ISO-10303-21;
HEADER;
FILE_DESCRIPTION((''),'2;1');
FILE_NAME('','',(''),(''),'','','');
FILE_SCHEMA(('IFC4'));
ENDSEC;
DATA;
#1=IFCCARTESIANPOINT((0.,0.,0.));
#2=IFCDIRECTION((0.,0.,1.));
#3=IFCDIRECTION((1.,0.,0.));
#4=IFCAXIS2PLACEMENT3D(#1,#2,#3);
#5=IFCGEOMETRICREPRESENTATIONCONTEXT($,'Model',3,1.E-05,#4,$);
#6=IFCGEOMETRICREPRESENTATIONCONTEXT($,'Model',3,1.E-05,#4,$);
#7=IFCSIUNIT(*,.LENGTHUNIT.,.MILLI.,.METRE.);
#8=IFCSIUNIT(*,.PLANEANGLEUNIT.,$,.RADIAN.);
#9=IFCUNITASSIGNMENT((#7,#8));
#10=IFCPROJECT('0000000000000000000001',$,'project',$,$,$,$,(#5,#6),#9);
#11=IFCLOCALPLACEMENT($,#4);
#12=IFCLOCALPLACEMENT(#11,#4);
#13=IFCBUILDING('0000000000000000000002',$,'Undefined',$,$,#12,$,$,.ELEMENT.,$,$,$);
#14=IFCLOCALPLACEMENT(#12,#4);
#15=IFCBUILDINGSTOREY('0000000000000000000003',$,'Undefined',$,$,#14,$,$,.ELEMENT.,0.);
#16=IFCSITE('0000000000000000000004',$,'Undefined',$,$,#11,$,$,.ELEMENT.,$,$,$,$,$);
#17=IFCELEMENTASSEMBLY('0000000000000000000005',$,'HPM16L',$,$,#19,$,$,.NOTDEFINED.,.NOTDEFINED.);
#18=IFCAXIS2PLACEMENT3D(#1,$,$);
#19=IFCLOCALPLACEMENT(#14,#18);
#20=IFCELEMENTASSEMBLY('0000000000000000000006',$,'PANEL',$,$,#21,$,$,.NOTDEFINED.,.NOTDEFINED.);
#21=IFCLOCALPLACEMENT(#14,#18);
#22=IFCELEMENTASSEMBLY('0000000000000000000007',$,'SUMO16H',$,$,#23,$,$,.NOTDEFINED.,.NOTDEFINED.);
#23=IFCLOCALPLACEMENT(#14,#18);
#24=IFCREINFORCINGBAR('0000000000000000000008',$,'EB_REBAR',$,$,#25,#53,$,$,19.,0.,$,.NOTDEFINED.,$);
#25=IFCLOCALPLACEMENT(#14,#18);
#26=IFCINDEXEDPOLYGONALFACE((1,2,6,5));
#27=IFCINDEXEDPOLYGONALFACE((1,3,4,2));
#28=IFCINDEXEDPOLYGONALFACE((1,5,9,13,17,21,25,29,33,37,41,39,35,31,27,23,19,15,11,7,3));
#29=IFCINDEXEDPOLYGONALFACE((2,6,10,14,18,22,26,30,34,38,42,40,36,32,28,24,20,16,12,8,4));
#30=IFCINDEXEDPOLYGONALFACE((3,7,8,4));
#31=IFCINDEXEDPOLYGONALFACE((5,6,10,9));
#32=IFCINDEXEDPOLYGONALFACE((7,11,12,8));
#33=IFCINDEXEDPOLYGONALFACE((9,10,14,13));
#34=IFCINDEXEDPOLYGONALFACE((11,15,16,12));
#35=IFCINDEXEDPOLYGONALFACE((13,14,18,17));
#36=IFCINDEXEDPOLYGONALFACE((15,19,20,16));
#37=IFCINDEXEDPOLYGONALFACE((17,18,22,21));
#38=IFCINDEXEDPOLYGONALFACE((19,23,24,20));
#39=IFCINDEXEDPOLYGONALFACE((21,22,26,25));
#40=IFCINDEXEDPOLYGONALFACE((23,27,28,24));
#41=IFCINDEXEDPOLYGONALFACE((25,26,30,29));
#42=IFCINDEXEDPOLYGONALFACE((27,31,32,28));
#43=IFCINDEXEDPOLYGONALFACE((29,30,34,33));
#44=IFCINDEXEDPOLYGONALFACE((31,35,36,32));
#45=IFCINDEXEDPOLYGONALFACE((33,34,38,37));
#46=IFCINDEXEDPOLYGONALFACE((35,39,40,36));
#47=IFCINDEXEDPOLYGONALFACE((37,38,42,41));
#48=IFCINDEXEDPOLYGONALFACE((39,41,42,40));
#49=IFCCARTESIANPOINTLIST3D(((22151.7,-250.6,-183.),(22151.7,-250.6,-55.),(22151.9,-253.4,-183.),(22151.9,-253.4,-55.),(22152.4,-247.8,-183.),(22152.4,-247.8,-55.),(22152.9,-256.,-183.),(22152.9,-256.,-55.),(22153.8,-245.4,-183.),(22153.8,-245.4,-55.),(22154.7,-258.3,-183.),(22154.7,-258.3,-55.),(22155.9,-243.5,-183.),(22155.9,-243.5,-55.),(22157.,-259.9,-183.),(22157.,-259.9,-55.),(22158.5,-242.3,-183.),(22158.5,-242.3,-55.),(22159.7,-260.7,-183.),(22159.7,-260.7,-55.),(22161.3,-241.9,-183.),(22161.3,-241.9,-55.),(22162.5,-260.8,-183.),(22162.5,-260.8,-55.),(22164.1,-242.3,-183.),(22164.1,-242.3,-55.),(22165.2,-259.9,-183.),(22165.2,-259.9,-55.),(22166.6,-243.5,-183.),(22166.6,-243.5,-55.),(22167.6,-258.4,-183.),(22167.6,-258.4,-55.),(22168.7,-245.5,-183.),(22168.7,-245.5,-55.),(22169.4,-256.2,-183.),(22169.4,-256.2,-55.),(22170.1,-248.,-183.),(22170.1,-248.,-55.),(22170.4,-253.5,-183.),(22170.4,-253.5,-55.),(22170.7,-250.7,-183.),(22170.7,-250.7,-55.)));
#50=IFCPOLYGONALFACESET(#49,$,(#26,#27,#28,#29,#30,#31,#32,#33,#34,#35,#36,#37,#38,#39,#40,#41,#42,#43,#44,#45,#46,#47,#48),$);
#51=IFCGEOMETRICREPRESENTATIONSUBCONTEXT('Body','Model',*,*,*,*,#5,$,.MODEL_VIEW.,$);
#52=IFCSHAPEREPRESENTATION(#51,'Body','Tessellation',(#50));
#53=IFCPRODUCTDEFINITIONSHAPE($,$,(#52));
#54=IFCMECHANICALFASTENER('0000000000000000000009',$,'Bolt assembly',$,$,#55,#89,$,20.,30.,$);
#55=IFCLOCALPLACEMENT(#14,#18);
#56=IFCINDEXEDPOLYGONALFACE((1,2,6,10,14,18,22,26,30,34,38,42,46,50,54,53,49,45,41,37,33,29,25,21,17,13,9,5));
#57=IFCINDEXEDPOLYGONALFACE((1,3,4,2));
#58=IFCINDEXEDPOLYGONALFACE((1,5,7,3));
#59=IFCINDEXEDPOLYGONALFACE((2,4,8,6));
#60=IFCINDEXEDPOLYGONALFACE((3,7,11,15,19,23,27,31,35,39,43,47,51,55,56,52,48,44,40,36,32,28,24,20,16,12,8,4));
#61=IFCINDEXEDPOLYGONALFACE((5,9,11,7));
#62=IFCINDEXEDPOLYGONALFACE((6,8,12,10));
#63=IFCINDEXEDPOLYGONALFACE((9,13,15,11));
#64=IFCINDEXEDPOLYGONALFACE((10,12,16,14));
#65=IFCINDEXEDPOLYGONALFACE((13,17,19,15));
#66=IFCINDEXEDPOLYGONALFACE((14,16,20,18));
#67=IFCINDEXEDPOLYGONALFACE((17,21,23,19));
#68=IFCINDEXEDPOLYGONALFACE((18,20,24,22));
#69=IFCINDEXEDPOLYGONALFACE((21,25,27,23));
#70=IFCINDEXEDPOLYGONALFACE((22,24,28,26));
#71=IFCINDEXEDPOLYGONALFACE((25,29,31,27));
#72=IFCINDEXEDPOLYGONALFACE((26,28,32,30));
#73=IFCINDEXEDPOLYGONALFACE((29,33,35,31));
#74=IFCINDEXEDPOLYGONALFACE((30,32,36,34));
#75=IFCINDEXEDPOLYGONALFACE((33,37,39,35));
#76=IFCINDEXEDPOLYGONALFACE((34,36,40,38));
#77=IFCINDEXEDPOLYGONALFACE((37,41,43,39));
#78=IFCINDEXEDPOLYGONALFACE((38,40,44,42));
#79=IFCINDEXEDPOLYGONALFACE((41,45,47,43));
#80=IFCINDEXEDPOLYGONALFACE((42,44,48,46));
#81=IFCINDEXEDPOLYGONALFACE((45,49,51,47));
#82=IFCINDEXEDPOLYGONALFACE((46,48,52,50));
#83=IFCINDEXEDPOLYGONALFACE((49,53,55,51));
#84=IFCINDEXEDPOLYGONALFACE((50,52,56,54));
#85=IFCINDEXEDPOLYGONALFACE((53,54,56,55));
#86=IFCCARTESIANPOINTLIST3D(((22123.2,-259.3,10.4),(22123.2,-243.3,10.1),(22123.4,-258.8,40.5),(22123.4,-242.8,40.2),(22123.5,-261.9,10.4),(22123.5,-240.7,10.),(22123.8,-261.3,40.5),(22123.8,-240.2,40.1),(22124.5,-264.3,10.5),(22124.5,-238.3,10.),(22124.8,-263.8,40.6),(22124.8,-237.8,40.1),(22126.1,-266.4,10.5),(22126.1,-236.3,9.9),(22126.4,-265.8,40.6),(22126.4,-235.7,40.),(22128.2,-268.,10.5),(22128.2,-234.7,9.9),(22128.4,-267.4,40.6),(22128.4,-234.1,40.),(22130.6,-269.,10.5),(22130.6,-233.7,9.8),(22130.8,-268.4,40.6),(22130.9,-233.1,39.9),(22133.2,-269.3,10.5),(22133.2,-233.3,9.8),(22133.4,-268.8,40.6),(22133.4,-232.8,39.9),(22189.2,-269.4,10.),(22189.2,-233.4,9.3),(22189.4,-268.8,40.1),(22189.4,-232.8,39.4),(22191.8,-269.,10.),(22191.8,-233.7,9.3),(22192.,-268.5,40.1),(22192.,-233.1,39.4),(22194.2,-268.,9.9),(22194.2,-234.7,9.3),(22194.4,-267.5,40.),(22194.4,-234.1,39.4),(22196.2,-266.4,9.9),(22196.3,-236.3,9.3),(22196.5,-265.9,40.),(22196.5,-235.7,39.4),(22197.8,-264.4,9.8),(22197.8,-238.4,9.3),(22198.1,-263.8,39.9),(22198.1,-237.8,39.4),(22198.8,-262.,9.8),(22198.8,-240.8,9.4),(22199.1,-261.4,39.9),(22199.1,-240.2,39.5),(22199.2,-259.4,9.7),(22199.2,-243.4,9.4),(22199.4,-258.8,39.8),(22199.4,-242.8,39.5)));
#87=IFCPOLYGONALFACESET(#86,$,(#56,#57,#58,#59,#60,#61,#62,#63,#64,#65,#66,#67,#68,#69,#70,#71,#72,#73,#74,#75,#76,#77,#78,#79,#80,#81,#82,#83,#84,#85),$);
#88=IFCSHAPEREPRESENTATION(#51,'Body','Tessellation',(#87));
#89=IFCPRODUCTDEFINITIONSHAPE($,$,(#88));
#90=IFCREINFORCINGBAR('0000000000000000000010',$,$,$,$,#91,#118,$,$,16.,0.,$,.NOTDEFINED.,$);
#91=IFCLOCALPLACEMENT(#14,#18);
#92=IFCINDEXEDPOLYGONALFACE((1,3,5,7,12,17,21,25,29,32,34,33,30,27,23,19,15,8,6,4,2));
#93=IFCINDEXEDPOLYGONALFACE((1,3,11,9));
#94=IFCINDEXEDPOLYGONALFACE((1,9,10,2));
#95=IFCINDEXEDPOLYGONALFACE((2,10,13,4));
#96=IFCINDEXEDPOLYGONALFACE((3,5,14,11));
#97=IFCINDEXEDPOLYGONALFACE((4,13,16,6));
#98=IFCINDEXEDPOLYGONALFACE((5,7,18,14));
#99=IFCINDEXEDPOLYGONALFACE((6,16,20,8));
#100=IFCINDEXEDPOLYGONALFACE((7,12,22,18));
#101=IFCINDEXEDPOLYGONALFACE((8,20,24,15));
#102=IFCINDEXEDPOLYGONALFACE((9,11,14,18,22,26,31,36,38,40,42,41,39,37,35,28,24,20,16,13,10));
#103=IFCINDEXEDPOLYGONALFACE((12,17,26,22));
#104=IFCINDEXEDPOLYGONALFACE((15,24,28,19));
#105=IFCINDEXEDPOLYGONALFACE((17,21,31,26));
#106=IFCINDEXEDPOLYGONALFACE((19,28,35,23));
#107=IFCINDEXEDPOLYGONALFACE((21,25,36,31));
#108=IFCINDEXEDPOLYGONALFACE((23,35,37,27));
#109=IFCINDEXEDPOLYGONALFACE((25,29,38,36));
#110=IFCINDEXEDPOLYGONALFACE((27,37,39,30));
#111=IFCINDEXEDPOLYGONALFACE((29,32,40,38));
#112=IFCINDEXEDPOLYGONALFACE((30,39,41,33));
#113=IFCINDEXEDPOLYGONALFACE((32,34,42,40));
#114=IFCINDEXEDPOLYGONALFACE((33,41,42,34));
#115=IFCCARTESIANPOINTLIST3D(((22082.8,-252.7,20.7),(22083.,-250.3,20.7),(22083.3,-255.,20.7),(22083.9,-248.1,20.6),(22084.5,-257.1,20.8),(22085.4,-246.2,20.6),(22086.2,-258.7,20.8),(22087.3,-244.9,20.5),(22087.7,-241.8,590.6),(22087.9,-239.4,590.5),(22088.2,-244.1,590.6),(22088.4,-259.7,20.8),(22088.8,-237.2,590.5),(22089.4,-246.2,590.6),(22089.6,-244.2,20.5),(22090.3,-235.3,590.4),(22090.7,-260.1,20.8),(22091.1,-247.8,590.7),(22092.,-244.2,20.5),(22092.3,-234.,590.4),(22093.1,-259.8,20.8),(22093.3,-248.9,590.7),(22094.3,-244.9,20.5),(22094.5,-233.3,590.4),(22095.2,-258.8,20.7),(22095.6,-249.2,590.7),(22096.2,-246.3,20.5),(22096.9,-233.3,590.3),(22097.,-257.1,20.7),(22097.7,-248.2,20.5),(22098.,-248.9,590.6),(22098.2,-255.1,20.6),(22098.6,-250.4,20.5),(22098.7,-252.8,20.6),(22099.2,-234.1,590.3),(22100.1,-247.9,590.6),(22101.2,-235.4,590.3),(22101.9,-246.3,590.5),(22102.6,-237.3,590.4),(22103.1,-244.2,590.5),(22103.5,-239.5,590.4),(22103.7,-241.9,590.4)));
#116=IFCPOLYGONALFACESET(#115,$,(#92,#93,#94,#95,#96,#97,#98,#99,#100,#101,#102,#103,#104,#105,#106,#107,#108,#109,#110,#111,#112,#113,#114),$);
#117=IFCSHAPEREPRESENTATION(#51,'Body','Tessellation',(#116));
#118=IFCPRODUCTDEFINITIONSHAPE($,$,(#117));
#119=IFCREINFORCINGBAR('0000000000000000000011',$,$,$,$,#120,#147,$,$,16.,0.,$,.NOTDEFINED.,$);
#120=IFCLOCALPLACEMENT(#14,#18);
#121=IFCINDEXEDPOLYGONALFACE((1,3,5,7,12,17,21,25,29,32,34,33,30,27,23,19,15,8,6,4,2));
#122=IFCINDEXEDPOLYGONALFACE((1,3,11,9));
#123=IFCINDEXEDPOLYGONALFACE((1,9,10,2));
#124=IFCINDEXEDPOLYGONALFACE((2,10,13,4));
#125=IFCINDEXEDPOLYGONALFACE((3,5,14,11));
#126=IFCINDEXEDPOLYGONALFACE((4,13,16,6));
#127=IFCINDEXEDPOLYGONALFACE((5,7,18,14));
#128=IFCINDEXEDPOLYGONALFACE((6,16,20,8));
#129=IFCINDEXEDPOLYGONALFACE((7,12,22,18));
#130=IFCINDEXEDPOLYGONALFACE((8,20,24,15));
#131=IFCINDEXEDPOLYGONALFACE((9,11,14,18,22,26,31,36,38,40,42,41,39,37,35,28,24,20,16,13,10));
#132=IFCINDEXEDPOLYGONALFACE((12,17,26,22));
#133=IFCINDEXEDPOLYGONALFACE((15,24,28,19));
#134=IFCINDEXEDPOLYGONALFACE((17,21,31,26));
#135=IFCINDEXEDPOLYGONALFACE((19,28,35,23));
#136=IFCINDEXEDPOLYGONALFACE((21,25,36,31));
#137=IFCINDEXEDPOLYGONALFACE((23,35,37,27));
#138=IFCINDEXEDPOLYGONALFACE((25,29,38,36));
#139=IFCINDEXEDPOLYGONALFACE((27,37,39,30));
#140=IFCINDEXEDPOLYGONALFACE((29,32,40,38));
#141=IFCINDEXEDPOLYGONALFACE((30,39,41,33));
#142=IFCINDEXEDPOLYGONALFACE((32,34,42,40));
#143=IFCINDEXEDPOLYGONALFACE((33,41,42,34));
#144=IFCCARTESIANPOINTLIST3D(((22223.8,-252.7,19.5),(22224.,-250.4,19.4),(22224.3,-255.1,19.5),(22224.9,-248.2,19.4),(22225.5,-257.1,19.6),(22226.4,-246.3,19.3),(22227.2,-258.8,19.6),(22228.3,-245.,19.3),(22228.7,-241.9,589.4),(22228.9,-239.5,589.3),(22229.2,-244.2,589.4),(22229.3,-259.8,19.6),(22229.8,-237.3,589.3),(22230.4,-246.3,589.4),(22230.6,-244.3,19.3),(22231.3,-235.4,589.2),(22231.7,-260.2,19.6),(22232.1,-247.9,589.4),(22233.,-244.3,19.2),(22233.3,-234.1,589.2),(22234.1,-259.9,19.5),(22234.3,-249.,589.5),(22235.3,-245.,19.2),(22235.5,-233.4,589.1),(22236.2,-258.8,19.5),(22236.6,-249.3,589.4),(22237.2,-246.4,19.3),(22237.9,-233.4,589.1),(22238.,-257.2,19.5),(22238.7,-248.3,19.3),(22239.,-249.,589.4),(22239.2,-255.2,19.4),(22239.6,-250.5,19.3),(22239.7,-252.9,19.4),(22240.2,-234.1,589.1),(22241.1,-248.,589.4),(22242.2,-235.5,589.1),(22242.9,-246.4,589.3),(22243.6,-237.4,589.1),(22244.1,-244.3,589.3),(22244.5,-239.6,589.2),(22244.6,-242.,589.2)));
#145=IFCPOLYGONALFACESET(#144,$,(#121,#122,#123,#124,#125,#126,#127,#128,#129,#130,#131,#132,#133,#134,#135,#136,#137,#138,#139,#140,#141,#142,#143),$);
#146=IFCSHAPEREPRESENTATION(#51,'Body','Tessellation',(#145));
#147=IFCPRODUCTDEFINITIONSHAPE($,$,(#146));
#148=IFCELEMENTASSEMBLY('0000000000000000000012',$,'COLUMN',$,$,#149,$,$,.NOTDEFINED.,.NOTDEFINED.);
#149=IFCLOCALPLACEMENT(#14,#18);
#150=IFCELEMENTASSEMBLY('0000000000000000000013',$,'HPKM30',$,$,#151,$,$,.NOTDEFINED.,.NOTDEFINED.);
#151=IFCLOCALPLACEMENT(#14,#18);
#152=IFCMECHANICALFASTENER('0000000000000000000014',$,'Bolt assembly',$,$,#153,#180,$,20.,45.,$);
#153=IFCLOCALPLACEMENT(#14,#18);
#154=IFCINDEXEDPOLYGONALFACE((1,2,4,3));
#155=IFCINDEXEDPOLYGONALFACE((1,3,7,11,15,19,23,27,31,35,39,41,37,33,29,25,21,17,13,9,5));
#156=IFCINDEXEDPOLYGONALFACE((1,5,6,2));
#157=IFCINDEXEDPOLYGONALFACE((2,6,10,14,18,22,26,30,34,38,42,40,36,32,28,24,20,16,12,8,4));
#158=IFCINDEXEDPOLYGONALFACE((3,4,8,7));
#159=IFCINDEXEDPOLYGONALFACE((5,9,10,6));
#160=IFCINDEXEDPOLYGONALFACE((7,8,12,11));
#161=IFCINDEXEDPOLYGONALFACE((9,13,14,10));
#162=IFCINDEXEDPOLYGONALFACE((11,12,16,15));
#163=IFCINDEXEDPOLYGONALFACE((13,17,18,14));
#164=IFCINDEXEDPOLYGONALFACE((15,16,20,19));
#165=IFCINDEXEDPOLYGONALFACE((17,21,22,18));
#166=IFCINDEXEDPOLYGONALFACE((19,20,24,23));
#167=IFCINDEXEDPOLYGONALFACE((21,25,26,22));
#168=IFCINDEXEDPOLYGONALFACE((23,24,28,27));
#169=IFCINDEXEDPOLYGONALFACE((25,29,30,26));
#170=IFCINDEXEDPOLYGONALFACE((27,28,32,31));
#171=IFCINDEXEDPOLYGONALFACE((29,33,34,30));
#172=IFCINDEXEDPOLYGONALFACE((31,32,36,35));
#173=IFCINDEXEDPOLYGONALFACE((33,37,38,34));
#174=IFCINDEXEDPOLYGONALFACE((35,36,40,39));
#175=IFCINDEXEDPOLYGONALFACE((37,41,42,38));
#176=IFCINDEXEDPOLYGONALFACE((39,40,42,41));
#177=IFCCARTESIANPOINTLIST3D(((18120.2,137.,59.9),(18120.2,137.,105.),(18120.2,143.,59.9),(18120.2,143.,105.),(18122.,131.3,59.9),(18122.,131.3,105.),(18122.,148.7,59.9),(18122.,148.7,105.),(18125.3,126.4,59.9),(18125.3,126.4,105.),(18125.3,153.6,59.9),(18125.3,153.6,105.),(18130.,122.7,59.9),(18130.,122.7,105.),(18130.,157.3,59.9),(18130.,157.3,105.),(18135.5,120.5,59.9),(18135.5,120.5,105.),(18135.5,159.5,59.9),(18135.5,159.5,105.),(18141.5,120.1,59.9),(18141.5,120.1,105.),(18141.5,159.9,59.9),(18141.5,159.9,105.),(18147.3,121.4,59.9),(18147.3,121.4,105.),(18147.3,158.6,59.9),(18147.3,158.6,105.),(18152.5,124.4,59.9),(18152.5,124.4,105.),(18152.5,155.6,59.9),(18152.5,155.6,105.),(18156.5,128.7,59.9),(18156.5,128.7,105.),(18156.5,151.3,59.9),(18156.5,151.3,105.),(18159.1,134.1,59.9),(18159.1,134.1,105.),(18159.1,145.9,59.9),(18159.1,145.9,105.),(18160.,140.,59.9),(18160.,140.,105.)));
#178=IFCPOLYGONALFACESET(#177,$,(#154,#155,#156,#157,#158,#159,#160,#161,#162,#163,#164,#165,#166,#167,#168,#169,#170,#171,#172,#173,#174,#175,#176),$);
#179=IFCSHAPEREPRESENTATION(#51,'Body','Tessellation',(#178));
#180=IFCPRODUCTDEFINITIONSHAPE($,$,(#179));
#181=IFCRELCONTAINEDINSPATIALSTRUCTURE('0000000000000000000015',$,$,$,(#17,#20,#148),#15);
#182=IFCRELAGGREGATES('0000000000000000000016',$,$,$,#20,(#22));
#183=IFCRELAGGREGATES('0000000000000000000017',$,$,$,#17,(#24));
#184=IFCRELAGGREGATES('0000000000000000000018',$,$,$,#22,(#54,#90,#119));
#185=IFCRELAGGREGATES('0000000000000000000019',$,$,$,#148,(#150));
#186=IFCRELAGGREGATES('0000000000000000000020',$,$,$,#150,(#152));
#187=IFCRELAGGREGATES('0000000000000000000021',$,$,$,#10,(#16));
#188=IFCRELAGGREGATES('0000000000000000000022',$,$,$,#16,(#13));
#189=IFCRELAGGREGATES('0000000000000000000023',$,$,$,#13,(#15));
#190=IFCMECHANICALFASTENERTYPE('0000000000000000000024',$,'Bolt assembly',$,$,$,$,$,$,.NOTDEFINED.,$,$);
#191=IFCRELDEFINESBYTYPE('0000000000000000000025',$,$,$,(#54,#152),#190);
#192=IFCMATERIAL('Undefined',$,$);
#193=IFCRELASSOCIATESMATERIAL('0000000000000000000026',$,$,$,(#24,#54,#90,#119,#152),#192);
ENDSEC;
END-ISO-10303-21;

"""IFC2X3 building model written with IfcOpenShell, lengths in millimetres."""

from ifc_helpers import new_model, entity, si_unit, frame, frame_2d, origin_with_axes, origin_2d_with_axis, place, context, subcontext, project, spatial, polyline, circle_curve, parameter, trimmed, segment, composite_curve, circle, outline, extrude, source, transform, mapped, material, type_object, element, aggregate, save


model = new_model("IFC2X3")

# Units and contexts
model_context_1 = context("Model", 3, precision=1e-05, world=origin_with_axes())
model_context_2 = context("Model", 3, precision=1e-05, world=origin_with_axes())
body_context = subcontext(model_context_1, "Body", "Model", "MODEL_VIEW")
ifc_project = project(units=[si_unit("LENGTHUNIT", "METRE", prefix="MILLI"), si_unit("PLANEANGLEUNIT", "RADIAN")], contexts=[model_context_1, model_context_2])

# Site, building, storey
site_placement = place(None, origin_with_axes())
site = spatial("IfcSite", under=ifc_project, at=site_placement, Name="Undefined", CompositionType="ELEMENT")
building_placement = place(site_placement, origin_with_axes())
building = spatial("IfcBuilding", under=site, at=building_placement, Name="Undefined", CompositionType="ELEMENT")
storey_placement = place(building_placement, origin_with_axes())
storey = spatial("IfcBuildingStorey", under=building, at=storey_placement, Name="Undefined", CompositionType="ELEMENT", Elevation=0.0)

# Element assembly
assembly_1_placement = place(storey_placement, origin_with_axes())
assembly_1 = element("IfcElementAssembly", 1, at=assembly_1_placement, inside=storey, Name="HPM16L", AssemblyPlace="NOTDEFINED", PredefinedType="NOTDEFINED")

# Element assemblies
assembly_2_placement = place(storey_placement, origin_with_axes())
assembly_2 = element("IfcElementAssembly", 2, at=assembly_2_placement, inside=storey, Name="PANEL", AssemblyPlace="NOTDEFINED", PredefinedType="NOTDEFINED")
assembly_3_placement = place(assembly_2_placement, origin_with_axes())
assembly_3 = element("IfcElementAssembly", 3, at=assembly_3_placement, Name="SUMO16H", AssemblyPlace="NOTDEFINED", PredefinedType="NOTDEFINED")

aggregate(assembly_2, [assembly_3])

# Reinforcing bar
ifc_material_1 = material(Name="Undefined")
shared_shape_1 = source(origin_with_axes(), body_context, "Body", "AdvancedSweptSolid", [
    entity("IfcSweptDiskSolid", entity("IfcTrimmedCurve", entity("IfcLine", entity("IfcCartesianPoint", [0.0, 0.0, 0.0]), entity("IfcVector", entity("IfcDirection", [1.0, 0.0, 0.0]), 1.0)), [entity("IfcParameterValue", 0.0)], [entity("IfcParameterValue", 128.0)], True, "PARAMETER"), 9.5, None, 0.0, 128.0),
])
reinforcing_bar_1_placement = place(assembly_1_placement, frame((22161.2, -251.4, -55.0), z_axis=(0.008664, 0.999962, 0.0), x_axis=(0.0, 0.0, -1.0)))
reinforcing_bar_1 = element("IfcReinforcingBar", 4, at=reinforcing_bar_1_placement, material=ifc_material_1, Name="EB_REBAR", BarRole="NOTDEFINED", CrossSectionArea=0.0, NominalDiameter=19.0, context=body_context, shape_type="MappedRepresentation", body=[
    mapped(shared_shape_1, transform((0.0, 0.0, 0.0))),
])
aggregate(assembly_1, [reinforcing_bar_1])

# Mechanical fastener
mechanical_fastener_type = type_object("IfcMechanicalFastenerType", Name="Bolt assembly")
shared_shape_2 = source(origin_with_axes(), body_context, "Body", "SweptSolid", [
    extrude(outline(composite_curve([segment(polyline([(-28.0, 18.0), (28.0, 18.0)]), True, "CONTINUOUS"), segment(trimmed(circle_curve(frame_2d((28.0, 8.0), x_axis=(0.0, 1.0)), 10.0), [parameter(0.0)], [parameter(4.712389)], False, "PARAMETER"), True, "CONTINUOUS"), segment(polyline([(38.0, 8.0), (38.0, -8.0)]), True, "CONTINUOUS"), segment(trimmed(circle_curve(frame_2d((28.0, -8.0), x_axis=(1.0, 0.0)), 10.0), [parameter(0.0)], [parameter(4.712389)], False, "PARAMETER"), True, "CONTINUOUS"), segment(polyline([(28.0, -18.0), (-28.0, -18.0)]), True, "CONTINUOUS"), segment(trimmed(circle_curve(frame_2d((-28.0, -8.0), x_axis=(0.0, -1.0)), 10.0), [parameter(0.0)], [parameter(4.712389)], False, "PARAMETER"), True, "CONTINUOUS"), segment(polyline([(-38.0, -8.0), (-38.0, 8.0)]), True, "CONTINUOUS"), segment(trimmed(circle_curve(frame_2d((-28.0, 8.0), x_axis=(-1.0, 0.0)), 10.0), [parameter(0.0)], [parameter(4.712389)], False, "PARAMETER"), True, "DISCONTINUOUS")], self_intersect=False)), frame((0.0, -30.0, 0.0), z_axis=(0.0, 1.0, 0.0), x_axis=(1.0, 0.0, 0.0)), (0.0, 0.0, 1.0), 30.1),
])
mechanical_fastener_1_placement = place(assembly_3_placement, frame((22161.2, -251.4, 10.0), z_axis=(-0.000494, -0.999818, 0.019097), x_axis=(-0.999963, 0.000658, 0.008607)))
mechanical_fastener_1 = element("IfcMechanicalFastener", 5, at=mechanical_fastener_1_placement, type_object=mechanical_fastener_type, material=ifc_material_1, Name="Bolt assembly", NominalDiameter=20.0, NominalLength=30.0, context=body_context, shape_type="MappedRepresentation", body=[
    mapped(shared_shape_2, transform((0.0, 0.0, 0.0))),
])

# Reinforcing bars
shared_shape_3 = source(origin_with_axes(), body_context, "Body", "AdvancedSweptSolid", [
    entity("IfcSweptDiskSolid", entity("IfcTrimmedCurve", entity("IfcLine", entity("IfcCartesianPoint", [0.0, 0.0, 0.0]), entity("IfcVector", entity("IfcDirection", [1.0, 0.0, 0.0]), 1.0)), [entity("IfcParameterValue", 0.0)], [entity("IfcParameterValue", 570.0)], True, "PARAMETER"), 8.0, None, 0.0, 570.0),
])
reinforcing_bar_2_placement = place(assembly_3_placement, frame((22090.8, -252.1, 20.6), z_axis=(-0.006955, -0.999792, 0.019153), x_axis=(0.008618, 0.019092, 0.999781)))
reinforcing_bar_2 = element("IfcReinforcingBar", 6, at=reinforcing_bar_2_placement, material=ifc_material_1, BarRole="NOTDEFINED", CrossSectionArea=0.0, NominalDiameter=16.0, context=body_context, shape_type="MappedRepresentation", body=[
    mapped(shared_shape_3, transform((0.0, 0.0, 0.0))),
])
shared_shape_4 = source(origin_with_axes(), body_context, "Body", "AdvancedSweptSolid", [
    entity("IfcSweptDiskSolid", entity("IfcTrimmedCurve", entity("IfcLine", entity("IfcCartesianPoint", [0.0, 0.0, 0.0]), entity("IfcVector", entity("IfcDirection", [1.0, 0.0, 0.0]), 1.0)), [entity("IfcParameterValue", 0.0)], [entity("IfcParameterValue", 570.0)], True, "PARAMETER"), 8.0, None, 0.0, 570.0),
])
reinforcing_bar_3_placement = place(assembly_3_placement, frame((22231.8, -252.2, 19.4), z_axis=(-0.006955, -0.999792, 0.019153), x_axis=(0.008618, 0.019092, 0.999781)))
reinforcing_bar_3 = element("IfcReinforcingBar", 7, at=reinforcing_bar_3_placement, material=ifc_material_1, BarRole="NOTDEFINED", CrossSectionArea=0.0, NominalDiameter=16.0, context=body_context, shape_type="MappedRepresentation", body=[
    mapped(shared_shape_4, transform((0.0, 0.0, 0.0))),
])
aggregate(assembly_3, [mechanical_fastener_1, reinforcing_bar_2, reinforcing_bar_3])

# Element assemblies, mechanical fastener
assembly_4_placement = place(storey_placement, origin_with_axes())
assembly_4 = element("IfcElementAssembly", 8, at=assembly_4_placement, inside=storey, Name="COLUMN", AssemblyPlace="NOTDEFINED", PredefinedType="NOTDEFINED")
assembly_5_placement = place(assembly_4_placement, origin_with_axes())
assembly_5 = element("IfcElementAssembly", 9, at=assembly_5_placement, Name="HPKM30", AssemblyPlace="NOTDEFINED", PredefinedType="NOTDEFINED")
aggregate(assembly_4, [assembly_5])
shared_shape_5 = source(origin_with_axes(), body_context, "Body", "SweptSolid", [
    extrude(circle(Radius=20.0, at=origin_2d_with_axis()), frame((0.0, -45.0, 0.0), z_axis=(0.0, 1.0, 0.0), x_axis=(1.0, 0.0, 0.0)), (0.0, 0.0, 1.0), 45.1),
])
mechanical_fastener_2_placement = place(assembly_5_placement, frame((18140.0, 140.0, 60.0), z_axis=(0.0, 1.0, 0.0), x_axis=(1.0, 0.0, 0.0)))
mechanical_fastener_2 = element("IfcMechanicalFastener", 10, at=mechanical_fastener_2_placement, type_object=mechanical_fastener_type, material=ifc_material_1, Name="Bolt assembly", NominalDiameter=20.0, NominalLength=45.0, context=body_context, shape_type="MappedRepresentation", body=[
    mapped(shared_shape_5, transform((0.0, 0.0, 0.0))),
])
aggregate(assembly_5, [mechanical_fastener_2])

save(model, "model.ifc")
